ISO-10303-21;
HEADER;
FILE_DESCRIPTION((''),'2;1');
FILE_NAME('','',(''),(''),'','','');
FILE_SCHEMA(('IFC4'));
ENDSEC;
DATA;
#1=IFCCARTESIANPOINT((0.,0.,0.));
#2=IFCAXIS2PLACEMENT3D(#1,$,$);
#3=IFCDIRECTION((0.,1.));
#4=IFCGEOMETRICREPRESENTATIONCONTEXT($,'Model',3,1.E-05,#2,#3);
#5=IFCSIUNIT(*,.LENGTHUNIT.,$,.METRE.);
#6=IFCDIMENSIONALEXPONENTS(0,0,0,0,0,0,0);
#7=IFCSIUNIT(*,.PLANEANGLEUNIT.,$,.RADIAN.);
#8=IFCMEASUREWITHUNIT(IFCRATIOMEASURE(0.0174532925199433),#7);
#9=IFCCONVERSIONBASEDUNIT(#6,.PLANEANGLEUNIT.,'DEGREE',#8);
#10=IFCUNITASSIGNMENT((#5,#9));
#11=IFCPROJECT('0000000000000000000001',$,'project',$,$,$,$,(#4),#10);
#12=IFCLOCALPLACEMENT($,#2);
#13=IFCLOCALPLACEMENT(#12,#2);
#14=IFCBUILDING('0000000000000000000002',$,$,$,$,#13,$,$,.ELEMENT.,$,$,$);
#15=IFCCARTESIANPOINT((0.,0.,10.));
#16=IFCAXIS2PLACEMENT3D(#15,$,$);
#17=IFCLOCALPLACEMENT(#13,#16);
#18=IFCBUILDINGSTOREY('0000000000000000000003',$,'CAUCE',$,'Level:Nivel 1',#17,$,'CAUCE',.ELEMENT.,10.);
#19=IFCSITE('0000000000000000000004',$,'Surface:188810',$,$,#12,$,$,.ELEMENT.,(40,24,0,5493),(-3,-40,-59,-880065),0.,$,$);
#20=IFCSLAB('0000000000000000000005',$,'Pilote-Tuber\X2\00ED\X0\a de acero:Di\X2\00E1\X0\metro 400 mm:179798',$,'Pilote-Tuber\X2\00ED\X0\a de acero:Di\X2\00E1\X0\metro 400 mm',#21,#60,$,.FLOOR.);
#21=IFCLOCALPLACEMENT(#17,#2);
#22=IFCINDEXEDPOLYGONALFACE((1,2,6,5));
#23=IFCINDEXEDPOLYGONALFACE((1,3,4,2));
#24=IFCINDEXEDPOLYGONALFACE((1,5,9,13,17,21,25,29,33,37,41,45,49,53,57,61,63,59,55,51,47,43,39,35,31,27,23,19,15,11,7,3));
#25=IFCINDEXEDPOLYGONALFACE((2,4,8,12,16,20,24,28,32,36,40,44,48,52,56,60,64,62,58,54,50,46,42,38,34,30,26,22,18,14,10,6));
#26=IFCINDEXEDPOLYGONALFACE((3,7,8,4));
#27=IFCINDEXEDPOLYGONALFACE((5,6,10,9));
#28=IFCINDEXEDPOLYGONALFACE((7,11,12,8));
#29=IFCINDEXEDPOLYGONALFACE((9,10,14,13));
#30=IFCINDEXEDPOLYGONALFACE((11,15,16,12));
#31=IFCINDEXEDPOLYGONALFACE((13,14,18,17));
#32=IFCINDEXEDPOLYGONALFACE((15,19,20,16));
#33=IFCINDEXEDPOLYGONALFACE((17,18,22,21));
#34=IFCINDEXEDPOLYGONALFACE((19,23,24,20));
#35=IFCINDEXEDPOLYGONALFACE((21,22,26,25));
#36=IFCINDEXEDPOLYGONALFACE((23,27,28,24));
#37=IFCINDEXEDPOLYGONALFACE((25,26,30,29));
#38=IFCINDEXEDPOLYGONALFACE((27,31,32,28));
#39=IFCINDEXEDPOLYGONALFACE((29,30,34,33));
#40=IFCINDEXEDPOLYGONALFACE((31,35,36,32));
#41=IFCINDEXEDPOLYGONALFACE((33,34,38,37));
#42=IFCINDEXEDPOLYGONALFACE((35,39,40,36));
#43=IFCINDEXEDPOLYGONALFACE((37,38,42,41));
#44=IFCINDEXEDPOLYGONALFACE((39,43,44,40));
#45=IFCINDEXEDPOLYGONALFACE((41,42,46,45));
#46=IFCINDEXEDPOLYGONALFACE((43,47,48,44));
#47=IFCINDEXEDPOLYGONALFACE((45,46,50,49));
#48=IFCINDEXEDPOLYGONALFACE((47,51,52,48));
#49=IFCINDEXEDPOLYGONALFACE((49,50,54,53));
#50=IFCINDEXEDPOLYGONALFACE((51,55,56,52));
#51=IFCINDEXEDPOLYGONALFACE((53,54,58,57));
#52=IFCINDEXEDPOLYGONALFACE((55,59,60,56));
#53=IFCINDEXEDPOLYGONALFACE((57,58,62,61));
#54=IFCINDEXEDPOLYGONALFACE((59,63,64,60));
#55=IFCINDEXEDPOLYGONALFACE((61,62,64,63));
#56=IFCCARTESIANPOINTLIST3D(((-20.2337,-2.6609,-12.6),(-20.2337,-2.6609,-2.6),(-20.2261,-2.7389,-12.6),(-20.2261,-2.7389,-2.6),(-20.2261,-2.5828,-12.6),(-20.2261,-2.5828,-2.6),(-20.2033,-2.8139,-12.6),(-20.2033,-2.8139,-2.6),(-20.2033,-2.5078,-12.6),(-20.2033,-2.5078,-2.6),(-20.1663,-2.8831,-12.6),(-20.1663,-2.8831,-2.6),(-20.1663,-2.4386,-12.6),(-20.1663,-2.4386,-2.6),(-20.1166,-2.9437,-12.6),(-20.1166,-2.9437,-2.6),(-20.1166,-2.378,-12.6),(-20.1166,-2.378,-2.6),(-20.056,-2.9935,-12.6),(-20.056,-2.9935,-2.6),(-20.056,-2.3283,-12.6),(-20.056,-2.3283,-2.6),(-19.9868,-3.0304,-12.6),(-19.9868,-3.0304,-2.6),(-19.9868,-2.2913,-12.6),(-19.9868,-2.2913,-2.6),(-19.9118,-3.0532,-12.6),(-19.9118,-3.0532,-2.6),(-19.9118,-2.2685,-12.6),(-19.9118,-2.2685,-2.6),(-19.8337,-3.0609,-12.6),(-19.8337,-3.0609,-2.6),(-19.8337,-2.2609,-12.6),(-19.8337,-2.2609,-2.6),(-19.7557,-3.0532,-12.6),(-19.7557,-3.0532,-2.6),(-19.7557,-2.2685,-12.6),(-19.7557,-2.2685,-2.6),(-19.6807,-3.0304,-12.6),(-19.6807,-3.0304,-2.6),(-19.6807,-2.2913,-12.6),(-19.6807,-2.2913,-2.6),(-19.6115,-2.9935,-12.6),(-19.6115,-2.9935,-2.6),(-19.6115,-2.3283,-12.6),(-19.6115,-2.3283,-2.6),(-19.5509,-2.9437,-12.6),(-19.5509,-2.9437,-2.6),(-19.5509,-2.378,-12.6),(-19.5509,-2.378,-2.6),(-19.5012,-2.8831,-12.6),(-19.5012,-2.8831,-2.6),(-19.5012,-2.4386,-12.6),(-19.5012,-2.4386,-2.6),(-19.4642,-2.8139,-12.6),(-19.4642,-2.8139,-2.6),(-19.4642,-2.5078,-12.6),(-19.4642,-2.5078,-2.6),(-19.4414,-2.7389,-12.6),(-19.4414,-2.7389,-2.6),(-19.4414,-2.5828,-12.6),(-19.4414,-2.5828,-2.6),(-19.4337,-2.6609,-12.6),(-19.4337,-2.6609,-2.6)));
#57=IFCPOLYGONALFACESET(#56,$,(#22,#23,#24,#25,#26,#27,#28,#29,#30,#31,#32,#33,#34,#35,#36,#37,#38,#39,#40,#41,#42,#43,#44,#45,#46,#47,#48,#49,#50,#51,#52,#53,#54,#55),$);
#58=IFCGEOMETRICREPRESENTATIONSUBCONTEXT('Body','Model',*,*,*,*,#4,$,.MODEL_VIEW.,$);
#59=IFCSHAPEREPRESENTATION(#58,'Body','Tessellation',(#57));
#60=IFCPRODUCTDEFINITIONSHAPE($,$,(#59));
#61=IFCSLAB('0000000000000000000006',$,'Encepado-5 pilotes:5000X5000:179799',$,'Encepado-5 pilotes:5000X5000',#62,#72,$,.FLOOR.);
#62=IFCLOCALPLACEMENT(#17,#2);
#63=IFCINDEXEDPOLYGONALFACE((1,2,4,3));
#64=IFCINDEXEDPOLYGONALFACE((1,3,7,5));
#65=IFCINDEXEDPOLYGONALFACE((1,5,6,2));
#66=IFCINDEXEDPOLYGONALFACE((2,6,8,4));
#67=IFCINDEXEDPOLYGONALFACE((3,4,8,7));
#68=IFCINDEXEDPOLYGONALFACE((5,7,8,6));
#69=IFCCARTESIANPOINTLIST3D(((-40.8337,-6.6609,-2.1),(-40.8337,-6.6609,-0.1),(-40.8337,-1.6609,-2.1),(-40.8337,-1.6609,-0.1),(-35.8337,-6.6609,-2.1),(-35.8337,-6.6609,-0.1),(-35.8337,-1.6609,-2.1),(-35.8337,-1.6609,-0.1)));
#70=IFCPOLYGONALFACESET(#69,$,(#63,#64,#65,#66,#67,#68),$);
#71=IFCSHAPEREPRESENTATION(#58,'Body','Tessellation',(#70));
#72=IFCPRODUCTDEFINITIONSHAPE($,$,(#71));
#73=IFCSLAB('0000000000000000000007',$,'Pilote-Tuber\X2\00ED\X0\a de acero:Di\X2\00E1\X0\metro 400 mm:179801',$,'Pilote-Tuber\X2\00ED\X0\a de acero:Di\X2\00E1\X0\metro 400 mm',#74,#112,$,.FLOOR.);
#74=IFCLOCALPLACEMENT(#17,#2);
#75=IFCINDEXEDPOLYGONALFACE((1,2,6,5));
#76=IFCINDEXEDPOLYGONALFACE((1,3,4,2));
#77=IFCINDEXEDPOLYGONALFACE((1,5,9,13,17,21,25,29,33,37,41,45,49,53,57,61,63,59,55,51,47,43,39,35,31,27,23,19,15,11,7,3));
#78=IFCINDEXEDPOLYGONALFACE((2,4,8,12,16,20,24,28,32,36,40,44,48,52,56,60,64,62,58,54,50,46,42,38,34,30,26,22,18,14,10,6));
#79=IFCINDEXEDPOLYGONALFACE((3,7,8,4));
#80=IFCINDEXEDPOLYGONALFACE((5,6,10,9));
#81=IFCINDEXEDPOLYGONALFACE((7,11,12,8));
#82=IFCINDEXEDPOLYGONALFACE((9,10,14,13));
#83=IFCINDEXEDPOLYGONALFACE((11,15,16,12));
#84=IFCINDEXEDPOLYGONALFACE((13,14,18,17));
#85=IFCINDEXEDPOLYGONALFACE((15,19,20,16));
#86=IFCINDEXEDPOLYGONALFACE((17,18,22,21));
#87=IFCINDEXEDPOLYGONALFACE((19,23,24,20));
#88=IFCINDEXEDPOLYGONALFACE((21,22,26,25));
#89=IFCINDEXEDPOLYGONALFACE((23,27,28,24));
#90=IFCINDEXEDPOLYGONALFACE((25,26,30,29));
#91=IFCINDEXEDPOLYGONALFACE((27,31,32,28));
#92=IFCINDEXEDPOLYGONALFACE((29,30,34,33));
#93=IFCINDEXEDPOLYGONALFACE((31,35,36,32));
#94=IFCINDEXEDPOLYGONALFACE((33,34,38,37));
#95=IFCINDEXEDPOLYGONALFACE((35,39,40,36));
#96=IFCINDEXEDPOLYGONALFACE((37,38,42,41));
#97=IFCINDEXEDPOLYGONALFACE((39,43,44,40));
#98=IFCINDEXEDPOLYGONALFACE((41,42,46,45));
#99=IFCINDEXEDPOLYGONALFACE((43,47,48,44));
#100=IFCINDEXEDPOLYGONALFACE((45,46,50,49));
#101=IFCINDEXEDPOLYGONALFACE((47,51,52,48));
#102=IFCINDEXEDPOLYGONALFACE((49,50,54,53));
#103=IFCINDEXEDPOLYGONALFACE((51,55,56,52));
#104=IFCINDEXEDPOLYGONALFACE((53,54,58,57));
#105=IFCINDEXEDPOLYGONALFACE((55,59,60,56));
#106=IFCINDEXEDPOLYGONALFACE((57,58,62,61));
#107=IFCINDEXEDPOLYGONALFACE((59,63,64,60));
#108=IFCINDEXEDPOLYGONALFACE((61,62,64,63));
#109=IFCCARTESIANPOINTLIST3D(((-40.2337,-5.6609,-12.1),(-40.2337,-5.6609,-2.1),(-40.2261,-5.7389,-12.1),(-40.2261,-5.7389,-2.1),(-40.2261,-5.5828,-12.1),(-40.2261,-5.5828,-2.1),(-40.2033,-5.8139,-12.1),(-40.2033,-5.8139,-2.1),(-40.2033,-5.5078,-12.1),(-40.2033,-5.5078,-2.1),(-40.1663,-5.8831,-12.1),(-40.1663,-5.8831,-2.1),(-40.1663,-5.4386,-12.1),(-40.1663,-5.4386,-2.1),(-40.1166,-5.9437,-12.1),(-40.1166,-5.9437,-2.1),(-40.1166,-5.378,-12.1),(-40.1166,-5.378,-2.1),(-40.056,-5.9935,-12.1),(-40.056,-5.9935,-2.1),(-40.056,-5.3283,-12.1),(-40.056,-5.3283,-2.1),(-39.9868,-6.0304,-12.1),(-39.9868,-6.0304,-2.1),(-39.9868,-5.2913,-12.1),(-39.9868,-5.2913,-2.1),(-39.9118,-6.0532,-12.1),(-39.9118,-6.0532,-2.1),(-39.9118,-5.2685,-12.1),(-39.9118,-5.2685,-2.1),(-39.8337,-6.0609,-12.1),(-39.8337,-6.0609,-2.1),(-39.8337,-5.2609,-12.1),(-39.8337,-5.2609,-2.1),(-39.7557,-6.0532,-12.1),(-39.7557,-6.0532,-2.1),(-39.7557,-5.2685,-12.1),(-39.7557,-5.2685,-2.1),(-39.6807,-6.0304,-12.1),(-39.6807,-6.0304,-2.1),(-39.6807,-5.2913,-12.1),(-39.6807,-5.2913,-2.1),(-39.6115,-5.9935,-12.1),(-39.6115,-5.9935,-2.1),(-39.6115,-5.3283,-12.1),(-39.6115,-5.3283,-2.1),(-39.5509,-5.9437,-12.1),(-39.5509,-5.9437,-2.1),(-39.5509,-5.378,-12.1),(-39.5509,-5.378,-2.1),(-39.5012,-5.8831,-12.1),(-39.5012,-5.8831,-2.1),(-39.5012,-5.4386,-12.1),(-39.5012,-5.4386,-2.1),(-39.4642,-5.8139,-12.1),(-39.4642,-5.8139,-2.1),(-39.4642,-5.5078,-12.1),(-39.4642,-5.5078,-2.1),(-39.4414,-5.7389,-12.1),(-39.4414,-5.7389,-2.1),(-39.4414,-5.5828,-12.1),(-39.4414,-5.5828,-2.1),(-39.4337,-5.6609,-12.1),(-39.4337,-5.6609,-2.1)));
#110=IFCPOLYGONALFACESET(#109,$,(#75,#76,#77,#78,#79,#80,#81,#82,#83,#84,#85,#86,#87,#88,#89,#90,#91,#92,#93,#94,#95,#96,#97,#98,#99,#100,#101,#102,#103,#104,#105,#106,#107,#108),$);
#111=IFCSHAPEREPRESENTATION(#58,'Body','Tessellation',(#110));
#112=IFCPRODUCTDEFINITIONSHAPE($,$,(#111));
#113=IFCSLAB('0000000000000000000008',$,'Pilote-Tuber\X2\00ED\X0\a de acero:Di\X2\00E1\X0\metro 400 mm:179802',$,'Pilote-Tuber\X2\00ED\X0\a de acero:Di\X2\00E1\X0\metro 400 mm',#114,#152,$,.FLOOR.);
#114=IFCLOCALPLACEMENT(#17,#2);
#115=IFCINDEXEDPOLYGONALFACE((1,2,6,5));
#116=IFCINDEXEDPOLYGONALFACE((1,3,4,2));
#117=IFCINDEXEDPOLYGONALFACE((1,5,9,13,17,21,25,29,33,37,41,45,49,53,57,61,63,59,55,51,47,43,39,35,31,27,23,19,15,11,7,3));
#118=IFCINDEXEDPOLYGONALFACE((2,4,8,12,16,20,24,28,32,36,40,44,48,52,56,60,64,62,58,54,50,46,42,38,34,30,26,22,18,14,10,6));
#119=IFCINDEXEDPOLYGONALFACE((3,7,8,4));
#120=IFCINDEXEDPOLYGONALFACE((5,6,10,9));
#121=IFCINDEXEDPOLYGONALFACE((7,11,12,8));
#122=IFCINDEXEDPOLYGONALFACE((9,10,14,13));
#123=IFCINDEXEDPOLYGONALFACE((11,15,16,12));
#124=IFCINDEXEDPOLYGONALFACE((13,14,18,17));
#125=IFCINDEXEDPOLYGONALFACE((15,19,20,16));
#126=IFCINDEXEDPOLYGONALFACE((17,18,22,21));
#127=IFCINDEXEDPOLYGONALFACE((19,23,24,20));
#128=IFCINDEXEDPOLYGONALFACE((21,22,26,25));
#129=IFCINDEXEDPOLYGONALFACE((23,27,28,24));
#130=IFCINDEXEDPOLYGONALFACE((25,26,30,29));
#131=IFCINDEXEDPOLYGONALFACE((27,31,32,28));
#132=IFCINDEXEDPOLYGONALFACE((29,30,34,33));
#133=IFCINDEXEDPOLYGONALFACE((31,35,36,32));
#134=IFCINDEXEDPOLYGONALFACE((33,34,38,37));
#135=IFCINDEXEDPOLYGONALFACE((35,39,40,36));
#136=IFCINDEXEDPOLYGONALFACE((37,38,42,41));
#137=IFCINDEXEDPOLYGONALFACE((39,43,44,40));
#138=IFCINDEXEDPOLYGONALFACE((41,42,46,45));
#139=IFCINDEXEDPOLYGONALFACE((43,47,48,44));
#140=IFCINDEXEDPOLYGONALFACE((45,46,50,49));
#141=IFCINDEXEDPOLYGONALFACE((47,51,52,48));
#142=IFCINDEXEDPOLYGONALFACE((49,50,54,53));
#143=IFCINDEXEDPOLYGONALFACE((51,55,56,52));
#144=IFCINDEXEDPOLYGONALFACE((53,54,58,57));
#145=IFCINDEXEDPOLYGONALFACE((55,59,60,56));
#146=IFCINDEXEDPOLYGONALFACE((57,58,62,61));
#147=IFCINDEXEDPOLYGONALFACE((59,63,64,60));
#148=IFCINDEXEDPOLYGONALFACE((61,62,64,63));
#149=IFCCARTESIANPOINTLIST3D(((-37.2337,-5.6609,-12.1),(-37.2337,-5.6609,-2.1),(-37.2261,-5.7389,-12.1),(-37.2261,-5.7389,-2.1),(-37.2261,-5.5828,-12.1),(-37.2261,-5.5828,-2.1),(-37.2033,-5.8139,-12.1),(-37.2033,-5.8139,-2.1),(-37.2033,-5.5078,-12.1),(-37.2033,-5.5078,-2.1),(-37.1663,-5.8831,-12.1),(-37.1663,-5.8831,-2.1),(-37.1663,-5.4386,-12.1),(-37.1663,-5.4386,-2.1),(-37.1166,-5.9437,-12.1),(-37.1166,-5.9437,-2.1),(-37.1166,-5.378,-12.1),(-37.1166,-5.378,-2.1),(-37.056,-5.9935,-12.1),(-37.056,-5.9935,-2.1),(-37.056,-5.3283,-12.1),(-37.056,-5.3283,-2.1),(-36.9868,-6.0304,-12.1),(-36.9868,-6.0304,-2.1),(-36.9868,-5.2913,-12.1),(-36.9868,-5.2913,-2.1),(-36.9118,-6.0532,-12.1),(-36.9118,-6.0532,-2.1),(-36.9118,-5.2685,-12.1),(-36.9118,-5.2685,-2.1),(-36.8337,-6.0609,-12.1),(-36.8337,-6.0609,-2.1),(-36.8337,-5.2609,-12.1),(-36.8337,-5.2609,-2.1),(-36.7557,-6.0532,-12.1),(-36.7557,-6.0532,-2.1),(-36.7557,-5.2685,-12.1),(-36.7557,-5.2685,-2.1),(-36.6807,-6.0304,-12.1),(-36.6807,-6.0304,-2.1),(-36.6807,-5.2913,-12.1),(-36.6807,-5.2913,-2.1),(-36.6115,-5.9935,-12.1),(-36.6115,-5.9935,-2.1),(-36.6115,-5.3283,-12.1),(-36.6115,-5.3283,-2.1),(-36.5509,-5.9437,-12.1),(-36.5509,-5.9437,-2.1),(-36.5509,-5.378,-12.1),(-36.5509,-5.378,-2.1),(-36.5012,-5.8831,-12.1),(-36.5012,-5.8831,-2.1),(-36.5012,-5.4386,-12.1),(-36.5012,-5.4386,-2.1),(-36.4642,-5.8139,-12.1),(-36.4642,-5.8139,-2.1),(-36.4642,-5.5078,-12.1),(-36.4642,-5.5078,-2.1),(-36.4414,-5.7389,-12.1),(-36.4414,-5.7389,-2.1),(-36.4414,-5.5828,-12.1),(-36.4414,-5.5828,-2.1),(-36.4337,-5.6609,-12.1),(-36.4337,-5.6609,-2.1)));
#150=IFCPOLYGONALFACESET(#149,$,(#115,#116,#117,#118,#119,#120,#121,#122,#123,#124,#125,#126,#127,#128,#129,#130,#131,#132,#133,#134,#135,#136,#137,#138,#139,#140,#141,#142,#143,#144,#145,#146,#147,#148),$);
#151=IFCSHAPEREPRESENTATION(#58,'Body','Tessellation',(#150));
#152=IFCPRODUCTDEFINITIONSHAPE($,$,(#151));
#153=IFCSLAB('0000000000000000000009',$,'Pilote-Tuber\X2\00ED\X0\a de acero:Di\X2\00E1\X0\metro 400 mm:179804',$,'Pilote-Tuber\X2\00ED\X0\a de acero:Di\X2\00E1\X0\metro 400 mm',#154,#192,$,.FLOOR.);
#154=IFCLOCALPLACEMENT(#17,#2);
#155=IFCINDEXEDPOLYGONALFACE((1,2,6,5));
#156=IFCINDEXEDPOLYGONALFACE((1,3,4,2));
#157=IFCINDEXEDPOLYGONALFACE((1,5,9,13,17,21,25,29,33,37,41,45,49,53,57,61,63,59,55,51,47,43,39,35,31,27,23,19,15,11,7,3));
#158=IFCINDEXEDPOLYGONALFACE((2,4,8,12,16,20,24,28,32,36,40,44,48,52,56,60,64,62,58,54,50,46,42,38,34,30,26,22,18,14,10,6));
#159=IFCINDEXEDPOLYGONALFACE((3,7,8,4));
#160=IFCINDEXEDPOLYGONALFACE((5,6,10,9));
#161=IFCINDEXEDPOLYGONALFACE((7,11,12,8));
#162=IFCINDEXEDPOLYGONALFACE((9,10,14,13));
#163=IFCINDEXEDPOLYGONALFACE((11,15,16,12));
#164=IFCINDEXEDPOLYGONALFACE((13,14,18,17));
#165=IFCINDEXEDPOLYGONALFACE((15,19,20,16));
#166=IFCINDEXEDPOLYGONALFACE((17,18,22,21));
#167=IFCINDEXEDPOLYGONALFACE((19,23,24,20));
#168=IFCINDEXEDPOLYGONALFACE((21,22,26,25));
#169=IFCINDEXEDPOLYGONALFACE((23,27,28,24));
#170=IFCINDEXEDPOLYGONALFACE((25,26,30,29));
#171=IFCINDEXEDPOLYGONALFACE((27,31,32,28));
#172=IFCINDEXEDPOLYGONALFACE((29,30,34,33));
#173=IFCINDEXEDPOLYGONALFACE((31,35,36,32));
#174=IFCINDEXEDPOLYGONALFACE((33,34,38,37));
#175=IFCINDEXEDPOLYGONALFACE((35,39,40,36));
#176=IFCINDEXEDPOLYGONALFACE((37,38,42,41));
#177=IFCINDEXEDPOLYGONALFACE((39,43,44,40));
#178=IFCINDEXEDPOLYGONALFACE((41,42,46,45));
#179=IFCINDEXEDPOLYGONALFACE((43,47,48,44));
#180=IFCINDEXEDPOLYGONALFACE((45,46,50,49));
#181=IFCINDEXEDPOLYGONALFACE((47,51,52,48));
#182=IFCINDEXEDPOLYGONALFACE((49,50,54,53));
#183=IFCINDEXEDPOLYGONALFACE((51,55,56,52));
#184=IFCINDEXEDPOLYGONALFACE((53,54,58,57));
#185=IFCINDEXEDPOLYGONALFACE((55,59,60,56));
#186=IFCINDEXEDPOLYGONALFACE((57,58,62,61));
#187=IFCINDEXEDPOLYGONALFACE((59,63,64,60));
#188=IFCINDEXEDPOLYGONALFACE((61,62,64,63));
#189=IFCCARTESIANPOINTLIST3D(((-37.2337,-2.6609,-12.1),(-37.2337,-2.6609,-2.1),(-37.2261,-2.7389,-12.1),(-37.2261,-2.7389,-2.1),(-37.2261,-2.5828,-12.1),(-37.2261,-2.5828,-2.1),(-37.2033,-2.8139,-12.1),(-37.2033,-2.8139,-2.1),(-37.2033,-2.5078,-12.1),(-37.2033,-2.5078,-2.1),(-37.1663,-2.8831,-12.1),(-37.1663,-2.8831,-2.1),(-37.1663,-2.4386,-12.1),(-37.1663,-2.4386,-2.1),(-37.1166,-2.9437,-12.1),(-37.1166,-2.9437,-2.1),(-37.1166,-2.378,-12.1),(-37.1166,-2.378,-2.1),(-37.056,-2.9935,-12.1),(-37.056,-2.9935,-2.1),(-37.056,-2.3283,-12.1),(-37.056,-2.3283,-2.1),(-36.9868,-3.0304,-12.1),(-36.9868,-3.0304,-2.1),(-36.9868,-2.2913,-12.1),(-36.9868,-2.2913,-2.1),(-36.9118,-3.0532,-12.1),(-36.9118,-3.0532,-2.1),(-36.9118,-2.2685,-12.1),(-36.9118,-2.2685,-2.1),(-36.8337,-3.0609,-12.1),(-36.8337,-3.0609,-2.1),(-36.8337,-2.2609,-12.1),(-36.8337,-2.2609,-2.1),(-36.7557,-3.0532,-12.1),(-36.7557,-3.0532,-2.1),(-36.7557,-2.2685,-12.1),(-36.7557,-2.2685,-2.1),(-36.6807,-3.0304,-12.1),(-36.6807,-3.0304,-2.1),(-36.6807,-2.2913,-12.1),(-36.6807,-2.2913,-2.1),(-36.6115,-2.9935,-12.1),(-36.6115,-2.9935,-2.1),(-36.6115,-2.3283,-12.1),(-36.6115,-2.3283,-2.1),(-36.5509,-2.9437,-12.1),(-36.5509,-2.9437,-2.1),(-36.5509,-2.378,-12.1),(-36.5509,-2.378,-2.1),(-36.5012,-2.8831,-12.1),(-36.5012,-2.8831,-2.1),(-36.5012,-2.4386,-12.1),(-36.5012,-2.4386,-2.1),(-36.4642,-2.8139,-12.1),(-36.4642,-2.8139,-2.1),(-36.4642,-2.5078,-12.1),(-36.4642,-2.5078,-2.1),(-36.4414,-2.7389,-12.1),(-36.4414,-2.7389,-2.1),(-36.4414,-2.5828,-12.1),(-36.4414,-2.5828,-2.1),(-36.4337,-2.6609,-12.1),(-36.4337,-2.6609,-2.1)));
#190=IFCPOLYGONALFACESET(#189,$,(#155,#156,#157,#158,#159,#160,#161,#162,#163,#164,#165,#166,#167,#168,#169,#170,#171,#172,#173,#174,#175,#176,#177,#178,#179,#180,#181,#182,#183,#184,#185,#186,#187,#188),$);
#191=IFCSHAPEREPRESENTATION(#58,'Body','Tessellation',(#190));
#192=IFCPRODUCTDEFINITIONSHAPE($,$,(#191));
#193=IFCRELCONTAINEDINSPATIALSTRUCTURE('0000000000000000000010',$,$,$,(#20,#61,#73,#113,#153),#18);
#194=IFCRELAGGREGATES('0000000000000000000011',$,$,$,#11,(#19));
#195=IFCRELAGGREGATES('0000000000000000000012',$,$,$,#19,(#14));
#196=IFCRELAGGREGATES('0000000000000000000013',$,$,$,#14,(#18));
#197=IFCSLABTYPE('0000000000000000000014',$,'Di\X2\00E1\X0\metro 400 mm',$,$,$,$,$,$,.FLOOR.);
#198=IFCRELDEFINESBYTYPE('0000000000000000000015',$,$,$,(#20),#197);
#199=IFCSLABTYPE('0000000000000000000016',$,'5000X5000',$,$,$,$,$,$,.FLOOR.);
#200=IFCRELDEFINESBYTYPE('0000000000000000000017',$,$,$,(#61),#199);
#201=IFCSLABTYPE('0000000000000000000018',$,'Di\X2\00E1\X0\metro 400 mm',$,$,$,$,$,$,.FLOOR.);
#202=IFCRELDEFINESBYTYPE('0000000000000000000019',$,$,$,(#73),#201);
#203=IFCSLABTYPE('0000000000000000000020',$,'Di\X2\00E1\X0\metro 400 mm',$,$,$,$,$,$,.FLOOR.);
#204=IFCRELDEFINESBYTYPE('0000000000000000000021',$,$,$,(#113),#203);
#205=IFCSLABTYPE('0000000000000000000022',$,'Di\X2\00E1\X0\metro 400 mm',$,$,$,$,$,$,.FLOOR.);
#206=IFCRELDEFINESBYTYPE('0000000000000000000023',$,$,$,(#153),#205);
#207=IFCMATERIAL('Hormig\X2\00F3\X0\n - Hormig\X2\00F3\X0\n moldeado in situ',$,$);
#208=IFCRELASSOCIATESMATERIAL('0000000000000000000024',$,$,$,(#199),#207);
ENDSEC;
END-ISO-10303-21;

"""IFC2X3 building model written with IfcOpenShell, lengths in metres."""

from ifc_helpers import new_model, entity, si_unit, converted_unit, direction, frame, frame_2d, origin, place, context, subcontext, project, spatial, rectangle, circle, extrude, material, type_object, element, save


model = new_model("IFC2X3")

# Units and contexts
model_context = context("Model", 3, precision=1e-05, world=origin(), true_north=direction((0.0, 1.0)))
body_context = subcontext(model_context, "Body", "Model", "MODEL_VIEW")
ifc_project = project(units=[si_unit("LENGTHUNIT", "METRE"), converted_unit("PLANEANGLEUNIT", "DEGREE", entity("IfcRatioMeasure", 0.0174532925199433), si_unit("PLANEANGLEUNIT", "RADIAN"), dimensions=[0, 0, 0, 0, 0, 0, 0])], contexts=[model_context])

# Site, building, storey
site_placement = place(None, origin())
site = spatial("IfcSite", under=ifc_project, at=site_placement, Name="Surface:188810", CompositionType="ELEMENT", RefLatitude=(40, 24, 0, 5493), RefLongitude=(-3, -40, -59, -880065), RefElevation=0.0)
building_placement = place(site_placement, origin())
building = spatial("IfcBuilding", under=site, at=building_placement, CompositionType="ELEMENT")
storey_placement = place(building_placement, frame((0.0, 0.0, 10.0)))
storey = spatial("IfcBuildingStorey", under=building, at=storey_placement, Name="CAUCE", ObjectType="Level:Nivel 1", LongName="CAUCE", CompositionType="ELEMENT", Elevation=10.0)

# Slabs
ifc_material_1 = material(Name="Hormigón - Hormigón moldeado in situ")
slab_type_1 = type_object("IfcSlabType", Name="Diámetro 400 mm", PredefinedType="FLOOR")
slab_1_placement = place(storey_placement, origin())
element("IfcSlab", 1, at=slab_1_placement, inside=storey, type_object=slab_type_1, Name="Pilote-Tubería de acero:Diámetro 400 mm:179798", ObjectType="Pilote-Tubería de acero:Diámetro 400 mm", PredefinedType="FLOOR", context=body_context, shape_type="SweptSolid", body=[
    extrude(circle(Radius=0.4, at=frame_2d((0.0, 0.0), x_axis=(1.0, 0.0))), frame((-19.8337, -2.6609, -12.6)), (0.0, 0.0, 1.0), 10.0),
])
slab_type_2 = type_object("IfcSlabType", Name="5000X5000", PredefinedType="FLOOR", material=ifc_material_1)
slab_2_placement = place(storey_placement, origin())
element("IfcSlab", 2, at=slab_2_placement, inside=storey, type_object=slab_type_2, Name="Encepado-5 pilotes:5000X5000:179799", ObjectType="Encepado-5 pilotes:5000X5000", PredefinedType="FLOOR", context=body_context, shape_type="SweptSolid", body=[
    extrude(rectangle(XDim=5.0, YDim=5.0, at=frame_2d((0.0, 0.0), x_axis=(1.0, 0.0))), frame((-38.3337, -4.1609, -2.1), z_axis=(0.0, 0.0, 1.0), x_axis=(-1.0, 0.0, 0.0)), (0.0, 0.0, 1.0), 2.0),
])
slab_type_3 = type_object("IfcSlabType", Name="Diámetro 400 mm", PredefinedType="FLOOR")
slab_3_placement = place(storey_placement, origin())
element("IfcSlab", 3, at=slab_3_placement, inside=storey, type_object=slab_type_3, Name="Pilote-Tubería de acero:Diámetro 400 mm:179801", ObjectType="Pilote-Tubería de acero:Diámetro 400 mm", PredefinedType="FLOOR", context=body_context, shape_type="SweptSolid", body=[
    extrude(circle(Radius=0.4, at=frame_2d((0.0, 0.0), x_axis=(1.0, 0.0))), frame((-39.8337, -5.6609, -12.1)), (0.0, 0.0, 1.0), 10.0),
])
slab_type_4 = type_object("IfcSlabType", Name="Diámetro 400 mm", PredefinedType="FLOOR")
slab_4_placement = place(storey_placement, origin())
element("IfcSlab", 4, at=slab_4_placement, inside=storey, type_object=slab_type_4, Name="Pilote-Tubería de acero:Diámetro 400 mm:179802", ObjectType="Pilote-Tubería de acero:Diámetro 400 mm", PredefinedType="FLOOR", context=body_context, shape_type="SweptSolid", body=[
    extrude(circle(Radius=0.4, at=frame_2d((0.0, 0.0), x_axis=(1.0, 0.0))), frame((-36.8337, -5.6609, -12.1)), (0.0, 0.0, 1.0), 10.0),
])
slab_type_5 = type_object("IfcSlabType", Name="Diámetro 400 mm", PredefinedType="FLOOR")
slab_5_placement = place(storey_placement, origin())
element("IfcSlab", 5, at=slab_5_placement, inside=storey, type_object=slab_type_5, Name="Pilote-Tubería de acero:Diámetro 400 mm:179804", ObjectType="Pilote-Tubería de acero:Diámetro 400 mm", PredefinedType="FLOOR", context=body_context, shape_type="SweptSolid", body=[
    extrude(circle(Radius=0.4, at=frame_2d((0.0, 0.0), x_axis=(1.0, 0.0))), frame((-36.8337, -2.6609, -12.1)), (0.0, 0.0, 1.0), 10.0),
])

save(model, "model.ifc")
